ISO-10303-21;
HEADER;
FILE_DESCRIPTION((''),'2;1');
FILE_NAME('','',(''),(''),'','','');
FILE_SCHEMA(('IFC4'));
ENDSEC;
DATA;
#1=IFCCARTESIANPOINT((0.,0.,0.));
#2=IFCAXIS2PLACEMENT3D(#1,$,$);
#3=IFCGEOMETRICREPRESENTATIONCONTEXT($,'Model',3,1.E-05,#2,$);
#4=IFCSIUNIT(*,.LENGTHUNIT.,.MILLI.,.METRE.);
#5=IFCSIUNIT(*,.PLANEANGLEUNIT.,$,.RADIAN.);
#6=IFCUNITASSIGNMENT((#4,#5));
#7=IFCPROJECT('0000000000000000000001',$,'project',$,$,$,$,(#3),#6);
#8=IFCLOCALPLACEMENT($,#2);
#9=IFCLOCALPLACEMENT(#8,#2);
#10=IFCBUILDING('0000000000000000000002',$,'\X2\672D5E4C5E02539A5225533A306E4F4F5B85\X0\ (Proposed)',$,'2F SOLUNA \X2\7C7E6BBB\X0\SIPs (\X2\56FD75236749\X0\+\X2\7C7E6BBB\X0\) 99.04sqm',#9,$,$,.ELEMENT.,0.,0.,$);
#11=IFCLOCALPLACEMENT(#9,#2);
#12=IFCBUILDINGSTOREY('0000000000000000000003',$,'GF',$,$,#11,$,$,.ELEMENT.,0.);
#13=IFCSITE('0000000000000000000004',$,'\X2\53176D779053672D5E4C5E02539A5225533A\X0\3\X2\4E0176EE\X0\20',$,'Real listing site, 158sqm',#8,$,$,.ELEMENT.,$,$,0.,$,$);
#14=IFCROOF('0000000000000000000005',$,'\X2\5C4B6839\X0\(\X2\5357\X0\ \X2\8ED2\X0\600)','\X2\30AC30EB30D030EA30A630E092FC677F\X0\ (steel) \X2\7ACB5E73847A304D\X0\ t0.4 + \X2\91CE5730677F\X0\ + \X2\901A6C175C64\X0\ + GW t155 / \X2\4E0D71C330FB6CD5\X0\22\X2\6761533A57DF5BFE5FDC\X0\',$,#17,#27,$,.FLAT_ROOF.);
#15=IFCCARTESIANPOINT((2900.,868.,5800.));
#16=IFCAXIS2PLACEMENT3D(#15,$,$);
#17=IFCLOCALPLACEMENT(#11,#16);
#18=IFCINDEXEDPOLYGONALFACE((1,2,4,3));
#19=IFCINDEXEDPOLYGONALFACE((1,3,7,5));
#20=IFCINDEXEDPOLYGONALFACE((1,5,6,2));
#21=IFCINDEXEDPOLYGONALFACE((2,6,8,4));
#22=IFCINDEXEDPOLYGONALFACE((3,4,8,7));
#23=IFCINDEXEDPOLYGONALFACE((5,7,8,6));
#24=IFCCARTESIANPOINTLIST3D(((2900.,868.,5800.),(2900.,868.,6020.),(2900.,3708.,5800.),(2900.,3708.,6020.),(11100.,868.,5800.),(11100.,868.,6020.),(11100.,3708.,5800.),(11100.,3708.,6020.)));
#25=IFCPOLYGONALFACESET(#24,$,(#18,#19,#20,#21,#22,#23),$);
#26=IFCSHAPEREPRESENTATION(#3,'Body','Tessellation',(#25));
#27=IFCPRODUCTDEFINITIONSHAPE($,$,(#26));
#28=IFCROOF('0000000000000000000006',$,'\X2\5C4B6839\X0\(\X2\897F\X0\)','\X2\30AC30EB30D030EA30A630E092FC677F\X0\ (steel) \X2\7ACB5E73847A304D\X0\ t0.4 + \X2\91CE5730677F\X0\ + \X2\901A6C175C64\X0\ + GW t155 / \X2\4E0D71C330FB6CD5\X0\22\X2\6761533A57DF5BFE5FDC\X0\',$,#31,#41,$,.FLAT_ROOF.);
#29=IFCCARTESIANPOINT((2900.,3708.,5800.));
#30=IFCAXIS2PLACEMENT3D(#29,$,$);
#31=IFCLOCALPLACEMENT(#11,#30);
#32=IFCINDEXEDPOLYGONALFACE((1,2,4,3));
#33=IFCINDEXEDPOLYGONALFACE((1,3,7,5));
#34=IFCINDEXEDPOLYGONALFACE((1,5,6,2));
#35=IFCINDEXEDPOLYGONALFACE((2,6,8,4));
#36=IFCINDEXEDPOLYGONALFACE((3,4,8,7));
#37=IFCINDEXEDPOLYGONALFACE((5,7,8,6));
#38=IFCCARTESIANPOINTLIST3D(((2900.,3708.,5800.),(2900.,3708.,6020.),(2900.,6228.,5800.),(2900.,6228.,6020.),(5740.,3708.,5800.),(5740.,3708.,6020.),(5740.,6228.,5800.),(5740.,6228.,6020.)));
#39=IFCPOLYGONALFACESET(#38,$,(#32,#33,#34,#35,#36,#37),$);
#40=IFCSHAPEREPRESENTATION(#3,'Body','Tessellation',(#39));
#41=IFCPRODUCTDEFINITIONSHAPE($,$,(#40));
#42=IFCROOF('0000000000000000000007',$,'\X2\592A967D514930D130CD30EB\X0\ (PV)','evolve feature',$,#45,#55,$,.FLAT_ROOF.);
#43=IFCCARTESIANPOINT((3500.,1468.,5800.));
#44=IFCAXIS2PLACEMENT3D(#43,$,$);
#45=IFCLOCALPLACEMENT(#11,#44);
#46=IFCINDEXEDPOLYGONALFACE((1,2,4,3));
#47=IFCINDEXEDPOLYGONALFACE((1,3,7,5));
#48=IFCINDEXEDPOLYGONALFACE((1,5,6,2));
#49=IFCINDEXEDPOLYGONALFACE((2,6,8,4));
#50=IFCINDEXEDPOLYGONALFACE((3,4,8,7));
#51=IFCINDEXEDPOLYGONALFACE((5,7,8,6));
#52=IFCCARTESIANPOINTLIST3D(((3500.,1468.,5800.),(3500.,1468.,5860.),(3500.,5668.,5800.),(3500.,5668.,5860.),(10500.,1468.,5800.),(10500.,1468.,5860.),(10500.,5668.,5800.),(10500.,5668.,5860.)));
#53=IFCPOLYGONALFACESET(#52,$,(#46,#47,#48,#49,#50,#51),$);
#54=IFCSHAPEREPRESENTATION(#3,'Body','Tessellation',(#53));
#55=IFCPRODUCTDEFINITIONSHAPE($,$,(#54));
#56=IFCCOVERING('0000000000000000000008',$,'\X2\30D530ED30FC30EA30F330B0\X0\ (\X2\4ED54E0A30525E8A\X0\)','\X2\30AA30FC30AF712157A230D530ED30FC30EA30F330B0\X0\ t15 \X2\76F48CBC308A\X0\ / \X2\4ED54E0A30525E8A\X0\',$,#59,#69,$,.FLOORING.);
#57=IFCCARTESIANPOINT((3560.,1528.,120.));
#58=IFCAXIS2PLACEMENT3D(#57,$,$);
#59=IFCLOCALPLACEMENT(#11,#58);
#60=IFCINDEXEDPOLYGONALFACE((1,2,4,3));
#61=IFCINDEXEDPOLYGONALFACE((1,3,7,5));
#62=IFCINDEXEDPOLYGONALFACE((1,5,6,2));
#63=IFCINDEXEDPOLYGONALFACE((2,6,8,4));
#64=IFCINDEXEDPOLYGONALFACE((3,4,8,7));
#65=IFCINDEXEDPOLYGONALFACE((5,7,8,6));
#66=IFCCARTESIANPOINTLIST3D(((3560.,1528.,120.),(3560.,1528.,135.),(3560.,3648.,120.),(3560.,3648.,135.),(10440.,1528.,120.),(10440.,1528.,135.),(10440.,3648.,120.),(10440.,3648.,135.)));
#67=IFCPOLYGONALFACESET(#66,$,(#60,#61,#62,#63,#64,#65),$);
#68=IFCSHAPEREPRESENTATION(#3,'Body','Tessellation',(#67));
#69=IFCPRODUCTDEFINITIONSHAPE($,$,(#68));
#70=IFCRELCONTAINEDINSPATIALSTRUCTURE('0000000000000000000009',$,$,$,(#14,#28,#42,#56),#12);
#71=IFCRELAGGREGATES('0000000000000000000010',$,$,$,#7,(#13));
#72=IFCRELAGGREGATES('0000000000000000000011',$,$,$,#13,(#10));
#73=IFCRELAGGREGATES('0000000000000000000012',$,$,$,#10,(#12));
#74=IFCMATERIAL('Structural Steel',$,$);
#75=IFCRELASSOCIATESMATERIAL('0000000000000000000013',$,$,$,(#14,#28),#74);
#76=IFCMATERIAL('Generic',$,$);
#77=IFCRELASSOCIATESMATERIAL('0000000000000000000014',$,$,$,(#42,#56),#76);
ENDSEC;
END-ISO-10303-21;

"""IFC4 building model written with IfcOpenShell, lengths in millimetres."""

from ifc_helpers import new_model, si_unit, frame, frame_2d, origin, place, context, project, spatial, rectangle, extrude, material, element, save


model = new_model("IFC4")

# Units and contexts
model_context = context("Model", 3, precision=1e-05, world=origin())
ifc_project = project(units=[si_unit("LENGTHUNIT", "METRE", prefix="MILLI"), si_unit("PLANEANGLEUNIT", "RADIAN")], contexts=[model_context])

# Site, building, storey
site_placement = place(None, origin())
site = spatial("IfcSite", under=ifc_project, at=site_placement, Name="北海道札幌市厚別区3丁目20", ObjectType="Real listing site, 158sqm", CompositionType="ELEMENT", RefElevation=0.0)
building_placement = place(site_placement, origin())
building = spatial("IfcBuilding", under=site, at=building_placement, Name="札幌市厚別区の住宅 (Proposed)", ObjectType="2F SOLUNA 籾殻SIPs (国産杉+籾殻) 99.04sqm", CompositionType="ELEMENT", ElevationOfRefHeight=0.0, ElevationOfTerrain=0.0)
storey_placement = place(building_placement, origin())
storey = spatial("IfcBuildingStorey", under=building, at=storey_placement, Name="GF", CompositionType="ELEMENT", Elevation=0.0)

# Shared definitions
ifc_material_1 = material(Name="Generic")

# Roofs
ifc_material_2 = material(Name="Structural Steel")
roof_1_placement = place(storey_placement, frame((2900.0, 868.0, 5800.0)))
element("IfcRoof", 1, at=roof_1_placement, inside=storey, material=ifc_material_2, Name="屋根(南 軒600)", Description="ガルバリウム鋼板 (steel) 立平葺き t0.4 + 野地板 + 通気層 + GW t155 / 不燃・法22条区域対応", PredefinedType="FLAT_ROOF", context=model_context, shape_type="SweptSolid", body=[
    extrude(rectangle(XDim=8200.0, YDim=2840.0, at=frame_2d((4100.0, 1420.0))), frame((2900.0, 868.0, 5800.0)), (0.0, 0.0, 1.0), 220.0),
])
roof_2_placement = place(storey_placement, frame((2900.0, 3708.0, 5800.0)))
element("IfcRoof", 2, at=roof_2_placement, inside=storey, material=ifc_material_2, Name="屋根(西)", Description="ガルバリウム鋼板 (steel) 立平葺き t0.4 + 野地板 + 通気層 + GW t155 / 不燃・法22条区域対応", PredefinedType="FLAT_ROOF", context=model_context, shape_type="SweptSolid", body=[
    extrude(rectangle(XDim=2840.0, YDim=2520.0, at=frame_2d((1420.0, 1260.0))), frame((2900.0, 3708.0, 5800.0)), (0.0, 0.0, 1.0), 220.0),
])
roof_3_placement = place(storey_placement, frame((3500.0, 1468.0, 5800.0)))
element("IfcRoof", 3, at=roof_3_placement, inside=storey, material=ifc_material_1, Name="太陽光パネル (PV)", Description="evolve feature", PredefinedType="FLAT_ROOF", context=model_context, shape_type="SweptSolid", body=[
    extrude(rectangle(XDim=7000.0, YDim=4200.0, at=frame_2d((3500.0, 2100.0))), frame((3500.0, 1468.0, 5800.0)), (0.0, 0.0, 1.0), 60.0),
])

# Covering
covering_placement = place(storey_placement, frame((3560.0, 1528.0, 120.0)))
element("IfcCovering", 4, at=covering_placement, inside=storey, material=ifc_material_1, Name="フローリング (仕上げ床)", Description="オーク無垢フローリング t15 直貼り / 仕上げ床", PredefinedType="FLOORING", context=model_context, shape_type="SweptSolid", body=[
    extrude(rectangle(XDim=6880.0, YDim=2120.0, at=frame_2d((3440.0, 1060.0))), frame((3560.0, 1528.0, 120.0)), (0.0, 0.0, 1.0), 15.0),
])

save(model, "model.ifc")
